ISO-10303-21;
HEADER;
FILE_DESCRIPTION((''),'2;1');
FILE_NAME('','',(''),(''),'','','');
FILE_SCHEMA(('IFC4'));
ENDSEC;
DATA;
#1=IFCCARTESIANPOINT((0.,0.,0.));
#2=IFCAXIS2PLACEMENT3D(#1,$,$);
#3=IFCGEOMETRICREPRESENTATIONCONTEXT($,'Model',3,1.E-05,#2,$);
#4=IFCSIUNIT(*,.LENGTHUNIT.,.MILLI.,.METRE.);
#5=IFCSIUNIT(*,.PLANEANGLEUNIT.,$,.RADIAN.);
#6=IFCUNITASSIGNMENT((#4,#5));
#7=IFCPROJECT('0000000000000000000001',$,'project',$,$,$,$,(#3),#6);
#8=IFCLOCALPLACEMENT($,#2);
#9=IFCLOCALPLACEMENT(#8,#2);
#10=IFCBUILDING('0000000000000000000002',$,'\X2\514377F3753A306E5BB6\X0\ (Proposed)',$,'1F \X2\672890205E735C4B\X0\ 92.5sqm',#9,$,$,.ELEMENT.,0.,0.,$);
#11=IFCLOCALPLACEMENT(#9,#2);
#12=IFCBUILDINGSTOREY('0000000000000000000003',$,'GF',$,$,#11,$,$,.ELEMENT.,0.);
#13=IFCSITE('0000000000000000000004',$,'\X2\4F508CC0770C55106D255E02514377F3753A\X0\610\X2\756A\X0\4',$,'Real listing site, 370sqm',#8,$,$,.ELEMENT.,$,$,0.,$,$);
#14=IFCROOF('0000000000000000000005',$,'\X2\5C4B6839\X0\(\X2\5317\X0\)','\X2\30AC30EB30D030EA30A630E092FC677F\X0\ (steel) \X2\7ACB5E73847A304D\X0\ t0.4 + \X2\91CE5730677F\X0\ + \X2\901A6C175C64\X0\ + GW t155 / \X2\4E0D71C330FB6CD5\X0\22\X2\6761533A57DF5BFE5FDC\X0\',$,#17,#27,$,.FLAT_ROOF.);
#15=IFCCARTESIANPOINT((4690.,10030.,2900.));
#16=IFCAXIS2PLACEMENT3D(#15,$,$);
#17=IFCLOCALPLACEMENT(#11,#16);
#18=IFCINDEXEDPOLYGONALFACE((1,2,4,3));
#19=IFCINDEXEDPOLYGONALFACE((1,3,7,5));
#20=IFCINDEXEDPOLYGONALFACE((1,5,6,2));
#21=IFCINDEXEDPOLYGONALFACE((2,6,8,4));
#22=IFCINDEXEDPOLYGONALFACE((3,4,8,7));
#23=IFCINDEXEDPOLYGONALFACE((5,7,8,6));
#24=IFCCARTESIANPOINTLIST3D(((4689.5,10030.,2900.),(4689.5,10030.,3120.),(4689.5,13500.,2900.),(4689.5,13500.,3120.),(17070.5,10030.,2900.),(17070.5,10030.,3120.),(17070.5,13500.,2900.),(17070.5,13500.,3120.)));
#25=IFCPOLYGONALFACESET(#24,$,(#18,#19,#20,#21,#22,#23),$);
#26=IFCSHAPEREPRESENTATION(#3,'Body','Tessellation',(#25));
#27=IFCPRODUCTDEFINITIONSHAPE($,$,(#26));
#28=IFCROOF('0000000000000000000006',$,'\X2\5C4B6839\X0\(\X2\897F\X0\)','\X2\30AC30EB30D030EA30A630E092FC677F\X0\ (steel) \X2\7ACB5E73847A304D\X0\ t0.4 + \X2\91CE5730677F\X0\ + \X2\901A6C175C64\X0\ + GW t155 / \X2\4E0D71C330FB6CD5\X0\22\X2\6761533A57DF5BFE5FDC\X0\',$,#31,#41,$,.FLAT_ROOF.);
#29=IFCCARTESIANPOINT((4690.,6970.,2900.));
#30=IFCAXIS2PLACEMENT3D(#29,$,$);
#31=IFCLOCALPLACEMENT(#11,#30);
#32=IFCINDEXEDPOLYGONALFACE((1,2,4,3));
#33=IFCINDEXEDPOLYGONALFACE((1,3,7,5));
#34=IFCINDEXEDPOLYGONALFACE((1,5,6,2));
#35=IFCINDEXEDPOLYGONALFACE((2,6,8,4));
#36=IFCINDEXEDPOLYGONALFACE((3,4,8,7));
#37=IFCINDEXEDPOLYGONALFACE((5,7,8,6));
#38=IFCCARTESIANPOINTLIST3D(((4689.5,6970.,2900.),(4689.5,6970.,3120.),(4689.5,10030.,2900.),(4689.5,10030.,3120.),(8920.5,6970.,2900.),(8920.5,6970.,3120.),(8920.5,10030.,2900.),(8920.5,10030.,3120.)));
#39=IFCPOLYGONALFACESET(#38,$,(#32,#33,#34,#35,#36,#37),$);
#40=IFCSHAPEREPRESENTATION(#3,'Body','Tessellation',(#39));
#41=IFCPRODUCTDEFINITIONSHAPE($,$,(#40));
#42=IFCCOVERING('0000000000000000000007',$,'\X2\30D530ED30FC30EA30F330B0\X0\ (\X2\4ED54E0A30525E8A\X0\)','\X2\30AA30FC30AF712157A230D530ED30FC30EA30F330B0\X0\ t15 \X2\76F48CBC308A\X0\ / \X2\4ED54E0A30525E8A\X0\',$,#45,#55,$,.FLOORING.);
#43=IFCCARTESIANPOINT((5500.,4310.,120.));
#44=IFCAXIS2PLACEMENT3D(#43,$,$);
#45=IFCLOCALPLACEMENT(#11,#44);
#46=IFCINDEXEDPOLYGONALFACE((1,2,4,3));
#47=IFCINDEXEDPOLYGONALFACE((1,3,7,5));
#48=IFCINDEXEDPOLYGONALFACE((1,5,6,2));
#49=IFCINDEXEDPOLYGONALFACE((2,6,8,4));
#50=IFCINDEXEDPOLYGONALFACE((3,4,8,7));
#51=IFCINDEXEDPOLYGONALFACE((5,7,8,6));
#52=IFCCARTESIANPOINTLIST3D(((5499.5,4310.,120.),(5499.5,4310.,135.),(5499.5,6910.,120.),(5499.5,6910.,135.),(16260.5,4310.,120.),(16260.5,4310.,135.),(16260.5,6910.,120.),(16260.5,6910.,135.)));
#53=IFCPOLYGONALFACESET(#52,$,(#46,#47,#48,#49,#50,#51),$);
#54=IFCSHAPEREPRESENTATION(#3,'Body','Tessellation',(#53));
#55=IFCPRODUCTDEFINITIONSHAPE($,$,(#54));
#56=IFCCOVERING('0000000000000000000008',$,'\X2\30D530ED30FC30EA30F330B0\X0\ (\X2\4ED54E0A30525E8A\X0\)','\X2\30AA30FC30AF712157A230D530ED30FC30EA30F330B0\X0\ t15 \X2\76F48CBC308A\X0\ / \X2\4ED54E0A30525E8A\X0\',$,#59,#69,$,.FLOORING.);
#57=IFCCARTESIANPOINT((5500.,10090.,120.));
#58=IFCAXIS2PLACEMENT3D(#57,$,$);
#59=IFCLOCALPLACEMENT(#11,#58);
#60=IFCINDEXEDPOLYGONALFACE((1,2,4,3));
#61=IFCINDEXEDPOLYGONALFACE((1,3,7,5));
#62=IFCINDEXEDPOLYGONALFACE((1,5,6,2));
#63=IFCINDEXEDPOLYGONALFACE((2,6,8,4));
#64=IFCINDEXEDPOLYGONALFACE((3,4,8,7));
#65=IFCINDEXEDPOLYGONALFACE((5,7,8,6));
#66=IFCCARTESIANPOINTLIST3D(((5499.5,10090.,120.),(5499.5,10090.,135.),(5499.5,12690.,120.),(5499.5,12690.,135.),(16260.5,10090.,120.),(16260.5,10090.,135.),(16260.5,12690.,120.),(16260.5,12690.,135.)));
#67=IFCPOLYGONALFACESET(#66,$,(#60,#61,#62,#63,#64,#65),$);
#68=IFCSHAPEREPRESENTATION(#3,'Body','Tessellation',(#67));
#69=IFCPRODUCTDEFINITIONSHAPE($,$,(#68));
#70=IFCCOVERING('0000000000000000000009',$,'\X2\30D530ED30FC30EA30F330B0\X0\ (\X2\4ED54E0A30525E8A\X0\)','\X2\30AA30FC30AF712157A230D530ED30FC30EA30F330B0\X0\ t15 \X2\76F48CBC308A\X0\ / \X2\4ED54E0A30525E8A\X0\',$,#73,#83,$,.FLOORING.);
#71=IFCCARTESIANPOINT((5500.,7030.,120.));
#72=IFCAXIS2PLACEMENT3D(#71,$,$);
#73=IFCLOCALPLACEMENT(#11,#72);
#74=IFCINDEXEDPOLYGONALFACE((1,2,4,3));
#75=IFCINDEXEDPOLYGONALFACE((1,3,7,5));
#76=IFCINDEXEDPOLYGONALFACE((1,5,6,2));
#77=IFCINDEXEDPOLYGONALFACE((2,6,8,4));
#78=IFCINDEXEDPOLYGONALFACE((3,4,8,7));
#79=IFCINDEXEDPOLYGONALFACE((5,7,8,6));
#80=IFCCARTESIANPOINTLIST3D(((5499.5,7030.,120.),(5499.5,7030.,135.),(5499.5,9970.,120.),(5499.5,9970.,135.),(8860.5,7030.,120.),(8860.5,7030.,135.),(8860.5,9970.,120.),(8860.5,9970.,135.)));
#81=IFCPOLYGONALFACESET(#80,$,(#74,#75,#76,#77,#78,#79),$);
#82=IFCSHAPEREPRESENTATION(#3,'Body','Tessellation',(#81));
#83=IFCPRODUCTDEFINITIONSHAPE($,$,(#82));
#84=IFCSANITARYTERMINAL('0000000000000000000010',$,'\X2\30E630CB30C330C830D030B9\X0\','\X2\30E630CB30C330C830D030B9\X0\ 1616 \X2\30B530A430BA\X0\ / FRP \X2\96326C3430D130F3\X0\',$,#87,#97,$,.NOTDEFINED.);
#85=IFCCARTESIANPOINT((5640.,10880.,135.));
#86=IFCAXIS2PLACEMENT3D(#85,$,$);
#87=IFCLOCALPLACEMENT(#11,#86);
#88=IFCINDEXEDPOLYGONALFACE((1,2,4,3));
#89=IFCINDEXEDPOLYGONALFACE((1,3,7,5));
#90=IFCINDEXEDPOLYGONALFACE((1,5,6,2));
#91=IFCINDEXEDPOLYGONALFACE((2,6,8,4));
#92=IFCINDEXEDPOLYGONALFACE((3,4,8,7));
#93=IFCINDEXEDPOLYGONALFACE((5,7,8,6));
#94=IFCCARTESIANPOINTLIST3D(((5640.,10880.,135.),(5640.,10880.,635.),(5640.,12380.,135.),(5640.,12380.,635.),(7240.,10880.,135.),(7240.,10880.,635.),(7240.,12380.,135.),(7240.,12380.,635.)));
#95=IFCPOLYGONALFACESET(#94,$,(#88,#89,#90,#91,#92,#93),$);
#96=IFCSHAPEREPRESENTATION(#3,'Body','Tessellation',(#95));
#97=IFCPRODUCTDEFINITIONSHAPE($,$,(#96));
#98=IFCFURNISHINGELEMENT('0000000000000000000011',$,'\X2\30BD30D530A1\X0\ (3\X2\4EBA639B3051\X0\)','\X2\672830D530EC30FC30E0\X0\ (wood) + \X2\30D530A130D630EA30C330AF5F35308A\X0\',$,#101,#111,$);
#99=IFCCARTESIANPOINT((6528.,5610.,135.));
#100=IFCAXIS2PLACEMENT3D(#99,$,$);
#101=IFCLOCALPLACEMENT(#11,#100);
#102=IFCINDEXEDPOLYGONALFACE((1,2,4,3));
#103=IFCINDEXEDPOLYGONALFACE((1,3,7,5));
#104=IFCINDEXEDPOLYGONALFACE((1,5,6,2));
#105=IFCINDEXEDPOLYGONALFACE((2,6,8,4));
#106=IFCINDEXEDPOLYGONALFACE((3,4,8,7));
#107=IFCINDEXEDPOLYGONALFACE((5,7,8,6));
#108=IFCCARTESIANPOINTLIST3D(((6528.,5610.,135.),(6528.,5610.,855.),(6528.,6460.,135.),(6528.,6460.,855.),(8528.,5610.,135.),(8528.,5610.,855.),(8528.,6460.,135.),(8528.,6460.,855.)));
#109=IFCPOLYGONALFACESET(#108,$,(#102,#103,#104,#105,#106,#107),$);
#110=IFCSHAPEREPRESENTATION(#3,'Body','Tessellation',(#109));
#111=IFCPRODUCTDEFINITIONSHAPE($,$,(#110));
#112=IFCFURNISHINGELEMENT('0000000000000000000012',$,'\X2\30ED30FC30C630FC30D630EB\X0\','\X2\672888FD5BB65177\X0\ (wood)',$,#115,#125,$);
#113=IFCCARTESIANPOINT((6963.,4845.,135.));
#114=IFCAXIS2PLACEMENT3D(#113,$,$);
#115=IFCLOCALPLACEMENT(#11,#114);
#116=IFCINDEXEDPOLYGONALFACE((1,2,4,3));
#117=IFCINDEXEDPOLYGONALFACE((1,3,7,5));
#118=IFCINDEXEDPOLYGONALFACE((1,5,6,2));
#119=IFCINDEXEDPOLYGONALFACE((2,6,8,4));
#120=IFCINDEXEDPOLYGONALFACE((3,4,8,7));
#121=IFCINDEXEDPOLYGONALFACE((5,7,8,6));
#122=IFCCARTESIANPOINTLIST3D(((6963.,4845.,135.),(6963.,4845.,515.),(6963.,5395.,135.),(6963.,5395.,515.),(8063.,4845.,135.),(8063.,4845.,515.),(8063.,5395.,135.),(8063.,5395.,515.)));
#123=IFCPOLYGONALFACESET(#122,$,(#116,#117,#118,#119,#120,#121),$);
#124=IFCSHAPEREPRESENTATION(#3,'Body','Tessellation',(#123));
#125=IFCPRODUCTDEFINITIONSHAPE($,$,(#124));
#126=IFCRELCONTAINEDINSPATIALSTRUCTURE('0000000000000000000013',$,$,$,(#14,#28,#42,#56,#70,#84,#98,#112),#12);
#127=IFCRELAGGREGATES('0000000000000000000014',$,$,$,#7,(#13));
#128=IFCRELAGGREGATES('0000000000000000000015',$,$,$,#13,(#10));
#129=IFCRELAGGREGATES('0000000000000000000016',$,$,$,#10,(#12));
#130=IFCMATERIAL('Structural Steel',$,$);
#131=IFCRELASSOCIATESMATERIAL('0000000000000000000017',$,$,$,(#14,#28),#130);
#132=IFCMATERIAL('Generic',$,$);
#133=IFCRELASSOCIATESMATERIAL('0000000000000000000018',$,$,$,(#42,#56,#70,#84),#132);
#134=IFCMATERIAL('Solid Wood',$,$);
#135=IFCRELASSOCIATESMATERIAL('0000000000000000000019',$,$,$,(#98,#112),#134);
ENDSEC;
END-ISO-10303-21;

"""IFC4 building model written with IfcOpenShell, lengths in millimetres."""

from ifc_helpers import new_model, si_unit, frame, frame_2d, origin, place, context, project, spatial, rectangle, extrude, material, element, save


model = new_model("IFC4")

# Units and contexts
model_context = context("Model", 3, precision=1e-05, world=origin())
ifc_project = project(units=[si_unit("LENGTHUNIT", "METRE", prefix="MILLI"), si_unit("PLANEANGLEUNIT", "RADIAN")], contexts=[model_context])

# Site, building, storey
site_placement = place(None, origin())
site = spatial("IfcSite", under=ifc_project, at=site_placement, Name="佐賀県唐津市元石町610番4", ObjectType="Real listing site, 370sqm", CompositionType="ELEMENT", RefElevation=0.0)
building_placement = place(site_placement, origin())
building = spatial("IfcBuilding", under=site, at=building_placement, Name="元石町の家 (Proposed)", ObjectType="1F 木造平屋 92.5sqm", CompositionType="ELEMENT", ElevationOfRefHeight=0.0, ElevationOfTerrain=0.0)
storey_placement = place(building_placement, origin())
storey = spatial("IfcBuildingStorey", under=building, at=storey_placement, Name="GF", CompositionType="ELEMENT", Elevation=0.0)

# Shared definitions
ifc_material_1 = material(Name="Solid Wood")

# Roofs
ifc_material_2 = material(Name="Structural Steel")
roof_1_placement = place(storey_placement, frame((4690.0, 10030.0, 2900.0)))
element("IfcRoof", 1, at=roof_1_placement, inside=storey, material=ifc_material_2, Name="屋根(北)", Description="ガルバリウム鋼板 (steel) 立平葺き t0.4 + 野地板 + 通気層 + GW t155 / 不燃・法22条区域対応", PredefinedType="FLAT_ROOF", context=model_context, shape_type="SweptSolid", body=[
    extrude(rectangle(XDim=12381.0, YDim=3470.0, at=frame_2d((6190.0, 1735.0))), frame((4690.0, 10030.0, 2900.0)), (0.0, 0.0, 1.0), 220.0),
])
roof_2_placement = place(storey_placement, frame((4690.0, 6970.0, 2900.0)))
element("IfcRoof", 2, at=roof_2_placement, inside=storey, material=ifc_material_2, Name="屋根(西)", Description="ガルバリウム鋼板 (steel) 立平葺き t0.4 + 野地板 + 通気層 + GW t155 / 不燃・法22条区域対応", PredefinedType="FLAT_ROOF", context=model_context, shape_type="SweptSolid", body=[
    extrude(rectangle(XDim=4231.0, YDim=3060.0, at=frame_2d((2115.0, 1530.0))), frame((4690.0, 6970.0, 2900.0)), (0.0, 0.0, 1.0), 220.0),
])

# Coverings
ifc_material_3 = material(Name="Generic")
covering_1_placement = place(storey_placement, frame((5500.0, 4310.0, 120.0)))
element("IfcCovering", 3, at=covering_1_placement, inside=storey, material=ifc_material_3, Name="フローリング (仕上げ床)", Description="オーク無垢フローリング t15 直貼り / 仕上げ床", PredefinedType="FLOORING", context=model_context, shape_type="SweptSolid", body=[
    extrude(rectangle(XDim=10761.0, YDim=2600.0, at=frame_2d((5380.0, 1300.0))), frame((5500.0, 4310.0, 120.0)), (0.0, 0.0, 1.0), 15.0),
])
covering_2_placement = place(storey_placement, frame((5500.0, 10090.0, 120.0)))
element("IfcCovering", 4, at=covering_2_placement, inside=storey, material=ifc_material_3, Name="フローリング (仕上げ床)", Description="オーク無垢フローリング t15 直貼り / 仕上げ床", PredefinedType="FLOORING", context=model_context, shape_type="SweptSolid", body=[
    extrude(rectangle(XDim=10761.0, YDim=2600.0, at=frame_2d((5380.0, 1300.0))), frame((5500.0, 10090.0, 120.0)), (0.0, 0.0, 1.0), 15.0),
])
covering_3_placement = place(storey_placement, frame((5500.0, 7030.0, 120.0)))
element("IfcCovering", 5, at=covering_3_placement, inside=storey, material=ifc_material_3, Name="フローリング (仕上げ床)", Description="オーク無垢フローリング t15 直貼り / 仕上げ床", PredefinedType="FLOORING", context=model_context, shape_type="SweptSolid", body=[
    extrude(rectangle(XDim=3361.0, YDim=2940.0, at=frame_2d((1680.0, 1470.0))), frame((5500.0, 7030.0, 120.0)), (0.0, 0.0, 1.0), 15.0),
])

# Sanitary terminal
sanitary_terminal_placement = place(storey_placement, frame((5640.0, 10880.0, 135.0)))
element("IfcSanitaryTerminal", 6, at=sanitary_terminal_placement, inside=storey, material=ifc_material_3, Name="ユニットバス", Description="ユニットバス 1616 サイズ / FRP 防水パン", PredefinedType="NOTDEFINED", context=model_context, shape_type="SweptSolid", body=[
    extrude(rectangle(XDim=1600.0, YDim=1500.0, at=frame_2d((800.0, 750.0))), frame((5640.0, 10880.0, 135.0)), (0.0, 0.0, 1.0), 500.0),
])

# Furnishing elements
furnishing_1_placement = place(storey_placement, frame((6528.0, 5610.0, 135.0)))
element("IfcFurnishingElement", 7, at=furnishing_1_placement, inside=storey, material=ifc_material_1, Name="ソファ (3人掛け)", Description="木フレーム (wood) + ファブリック張り", context=model_context, shape_type="SweptSolid", body=[
    extrude(rectangle(XDim=2000.0, YDim=850.0, at=frame_2d((1000.0, 425.0))), frame((6528.0, 5610.0, 135.0)), (0.0, 0.0, 1.0), 720.0),
])
furnishing_2_placement = place(storey_placement, frame((6963.0, 4845.0, 135.0)))
element("IfcFurnishingElement", 8, at=furnishing_2_placement, inside=storey, material=ifc_material_1, Name="ローテーブル", Description="木製家具 (wood)", context=model_context, shape_type="SweptSolid", body=[
    extrude(rectangle(XDim=1100.0, YDim=550.0, at=frame_2d((550.0, 275.0))), frame((6963.0, 4845.0, 135.0)), (0.0, 0.0, 1.0), 380.0),
])

save(model, "model.ifc")
